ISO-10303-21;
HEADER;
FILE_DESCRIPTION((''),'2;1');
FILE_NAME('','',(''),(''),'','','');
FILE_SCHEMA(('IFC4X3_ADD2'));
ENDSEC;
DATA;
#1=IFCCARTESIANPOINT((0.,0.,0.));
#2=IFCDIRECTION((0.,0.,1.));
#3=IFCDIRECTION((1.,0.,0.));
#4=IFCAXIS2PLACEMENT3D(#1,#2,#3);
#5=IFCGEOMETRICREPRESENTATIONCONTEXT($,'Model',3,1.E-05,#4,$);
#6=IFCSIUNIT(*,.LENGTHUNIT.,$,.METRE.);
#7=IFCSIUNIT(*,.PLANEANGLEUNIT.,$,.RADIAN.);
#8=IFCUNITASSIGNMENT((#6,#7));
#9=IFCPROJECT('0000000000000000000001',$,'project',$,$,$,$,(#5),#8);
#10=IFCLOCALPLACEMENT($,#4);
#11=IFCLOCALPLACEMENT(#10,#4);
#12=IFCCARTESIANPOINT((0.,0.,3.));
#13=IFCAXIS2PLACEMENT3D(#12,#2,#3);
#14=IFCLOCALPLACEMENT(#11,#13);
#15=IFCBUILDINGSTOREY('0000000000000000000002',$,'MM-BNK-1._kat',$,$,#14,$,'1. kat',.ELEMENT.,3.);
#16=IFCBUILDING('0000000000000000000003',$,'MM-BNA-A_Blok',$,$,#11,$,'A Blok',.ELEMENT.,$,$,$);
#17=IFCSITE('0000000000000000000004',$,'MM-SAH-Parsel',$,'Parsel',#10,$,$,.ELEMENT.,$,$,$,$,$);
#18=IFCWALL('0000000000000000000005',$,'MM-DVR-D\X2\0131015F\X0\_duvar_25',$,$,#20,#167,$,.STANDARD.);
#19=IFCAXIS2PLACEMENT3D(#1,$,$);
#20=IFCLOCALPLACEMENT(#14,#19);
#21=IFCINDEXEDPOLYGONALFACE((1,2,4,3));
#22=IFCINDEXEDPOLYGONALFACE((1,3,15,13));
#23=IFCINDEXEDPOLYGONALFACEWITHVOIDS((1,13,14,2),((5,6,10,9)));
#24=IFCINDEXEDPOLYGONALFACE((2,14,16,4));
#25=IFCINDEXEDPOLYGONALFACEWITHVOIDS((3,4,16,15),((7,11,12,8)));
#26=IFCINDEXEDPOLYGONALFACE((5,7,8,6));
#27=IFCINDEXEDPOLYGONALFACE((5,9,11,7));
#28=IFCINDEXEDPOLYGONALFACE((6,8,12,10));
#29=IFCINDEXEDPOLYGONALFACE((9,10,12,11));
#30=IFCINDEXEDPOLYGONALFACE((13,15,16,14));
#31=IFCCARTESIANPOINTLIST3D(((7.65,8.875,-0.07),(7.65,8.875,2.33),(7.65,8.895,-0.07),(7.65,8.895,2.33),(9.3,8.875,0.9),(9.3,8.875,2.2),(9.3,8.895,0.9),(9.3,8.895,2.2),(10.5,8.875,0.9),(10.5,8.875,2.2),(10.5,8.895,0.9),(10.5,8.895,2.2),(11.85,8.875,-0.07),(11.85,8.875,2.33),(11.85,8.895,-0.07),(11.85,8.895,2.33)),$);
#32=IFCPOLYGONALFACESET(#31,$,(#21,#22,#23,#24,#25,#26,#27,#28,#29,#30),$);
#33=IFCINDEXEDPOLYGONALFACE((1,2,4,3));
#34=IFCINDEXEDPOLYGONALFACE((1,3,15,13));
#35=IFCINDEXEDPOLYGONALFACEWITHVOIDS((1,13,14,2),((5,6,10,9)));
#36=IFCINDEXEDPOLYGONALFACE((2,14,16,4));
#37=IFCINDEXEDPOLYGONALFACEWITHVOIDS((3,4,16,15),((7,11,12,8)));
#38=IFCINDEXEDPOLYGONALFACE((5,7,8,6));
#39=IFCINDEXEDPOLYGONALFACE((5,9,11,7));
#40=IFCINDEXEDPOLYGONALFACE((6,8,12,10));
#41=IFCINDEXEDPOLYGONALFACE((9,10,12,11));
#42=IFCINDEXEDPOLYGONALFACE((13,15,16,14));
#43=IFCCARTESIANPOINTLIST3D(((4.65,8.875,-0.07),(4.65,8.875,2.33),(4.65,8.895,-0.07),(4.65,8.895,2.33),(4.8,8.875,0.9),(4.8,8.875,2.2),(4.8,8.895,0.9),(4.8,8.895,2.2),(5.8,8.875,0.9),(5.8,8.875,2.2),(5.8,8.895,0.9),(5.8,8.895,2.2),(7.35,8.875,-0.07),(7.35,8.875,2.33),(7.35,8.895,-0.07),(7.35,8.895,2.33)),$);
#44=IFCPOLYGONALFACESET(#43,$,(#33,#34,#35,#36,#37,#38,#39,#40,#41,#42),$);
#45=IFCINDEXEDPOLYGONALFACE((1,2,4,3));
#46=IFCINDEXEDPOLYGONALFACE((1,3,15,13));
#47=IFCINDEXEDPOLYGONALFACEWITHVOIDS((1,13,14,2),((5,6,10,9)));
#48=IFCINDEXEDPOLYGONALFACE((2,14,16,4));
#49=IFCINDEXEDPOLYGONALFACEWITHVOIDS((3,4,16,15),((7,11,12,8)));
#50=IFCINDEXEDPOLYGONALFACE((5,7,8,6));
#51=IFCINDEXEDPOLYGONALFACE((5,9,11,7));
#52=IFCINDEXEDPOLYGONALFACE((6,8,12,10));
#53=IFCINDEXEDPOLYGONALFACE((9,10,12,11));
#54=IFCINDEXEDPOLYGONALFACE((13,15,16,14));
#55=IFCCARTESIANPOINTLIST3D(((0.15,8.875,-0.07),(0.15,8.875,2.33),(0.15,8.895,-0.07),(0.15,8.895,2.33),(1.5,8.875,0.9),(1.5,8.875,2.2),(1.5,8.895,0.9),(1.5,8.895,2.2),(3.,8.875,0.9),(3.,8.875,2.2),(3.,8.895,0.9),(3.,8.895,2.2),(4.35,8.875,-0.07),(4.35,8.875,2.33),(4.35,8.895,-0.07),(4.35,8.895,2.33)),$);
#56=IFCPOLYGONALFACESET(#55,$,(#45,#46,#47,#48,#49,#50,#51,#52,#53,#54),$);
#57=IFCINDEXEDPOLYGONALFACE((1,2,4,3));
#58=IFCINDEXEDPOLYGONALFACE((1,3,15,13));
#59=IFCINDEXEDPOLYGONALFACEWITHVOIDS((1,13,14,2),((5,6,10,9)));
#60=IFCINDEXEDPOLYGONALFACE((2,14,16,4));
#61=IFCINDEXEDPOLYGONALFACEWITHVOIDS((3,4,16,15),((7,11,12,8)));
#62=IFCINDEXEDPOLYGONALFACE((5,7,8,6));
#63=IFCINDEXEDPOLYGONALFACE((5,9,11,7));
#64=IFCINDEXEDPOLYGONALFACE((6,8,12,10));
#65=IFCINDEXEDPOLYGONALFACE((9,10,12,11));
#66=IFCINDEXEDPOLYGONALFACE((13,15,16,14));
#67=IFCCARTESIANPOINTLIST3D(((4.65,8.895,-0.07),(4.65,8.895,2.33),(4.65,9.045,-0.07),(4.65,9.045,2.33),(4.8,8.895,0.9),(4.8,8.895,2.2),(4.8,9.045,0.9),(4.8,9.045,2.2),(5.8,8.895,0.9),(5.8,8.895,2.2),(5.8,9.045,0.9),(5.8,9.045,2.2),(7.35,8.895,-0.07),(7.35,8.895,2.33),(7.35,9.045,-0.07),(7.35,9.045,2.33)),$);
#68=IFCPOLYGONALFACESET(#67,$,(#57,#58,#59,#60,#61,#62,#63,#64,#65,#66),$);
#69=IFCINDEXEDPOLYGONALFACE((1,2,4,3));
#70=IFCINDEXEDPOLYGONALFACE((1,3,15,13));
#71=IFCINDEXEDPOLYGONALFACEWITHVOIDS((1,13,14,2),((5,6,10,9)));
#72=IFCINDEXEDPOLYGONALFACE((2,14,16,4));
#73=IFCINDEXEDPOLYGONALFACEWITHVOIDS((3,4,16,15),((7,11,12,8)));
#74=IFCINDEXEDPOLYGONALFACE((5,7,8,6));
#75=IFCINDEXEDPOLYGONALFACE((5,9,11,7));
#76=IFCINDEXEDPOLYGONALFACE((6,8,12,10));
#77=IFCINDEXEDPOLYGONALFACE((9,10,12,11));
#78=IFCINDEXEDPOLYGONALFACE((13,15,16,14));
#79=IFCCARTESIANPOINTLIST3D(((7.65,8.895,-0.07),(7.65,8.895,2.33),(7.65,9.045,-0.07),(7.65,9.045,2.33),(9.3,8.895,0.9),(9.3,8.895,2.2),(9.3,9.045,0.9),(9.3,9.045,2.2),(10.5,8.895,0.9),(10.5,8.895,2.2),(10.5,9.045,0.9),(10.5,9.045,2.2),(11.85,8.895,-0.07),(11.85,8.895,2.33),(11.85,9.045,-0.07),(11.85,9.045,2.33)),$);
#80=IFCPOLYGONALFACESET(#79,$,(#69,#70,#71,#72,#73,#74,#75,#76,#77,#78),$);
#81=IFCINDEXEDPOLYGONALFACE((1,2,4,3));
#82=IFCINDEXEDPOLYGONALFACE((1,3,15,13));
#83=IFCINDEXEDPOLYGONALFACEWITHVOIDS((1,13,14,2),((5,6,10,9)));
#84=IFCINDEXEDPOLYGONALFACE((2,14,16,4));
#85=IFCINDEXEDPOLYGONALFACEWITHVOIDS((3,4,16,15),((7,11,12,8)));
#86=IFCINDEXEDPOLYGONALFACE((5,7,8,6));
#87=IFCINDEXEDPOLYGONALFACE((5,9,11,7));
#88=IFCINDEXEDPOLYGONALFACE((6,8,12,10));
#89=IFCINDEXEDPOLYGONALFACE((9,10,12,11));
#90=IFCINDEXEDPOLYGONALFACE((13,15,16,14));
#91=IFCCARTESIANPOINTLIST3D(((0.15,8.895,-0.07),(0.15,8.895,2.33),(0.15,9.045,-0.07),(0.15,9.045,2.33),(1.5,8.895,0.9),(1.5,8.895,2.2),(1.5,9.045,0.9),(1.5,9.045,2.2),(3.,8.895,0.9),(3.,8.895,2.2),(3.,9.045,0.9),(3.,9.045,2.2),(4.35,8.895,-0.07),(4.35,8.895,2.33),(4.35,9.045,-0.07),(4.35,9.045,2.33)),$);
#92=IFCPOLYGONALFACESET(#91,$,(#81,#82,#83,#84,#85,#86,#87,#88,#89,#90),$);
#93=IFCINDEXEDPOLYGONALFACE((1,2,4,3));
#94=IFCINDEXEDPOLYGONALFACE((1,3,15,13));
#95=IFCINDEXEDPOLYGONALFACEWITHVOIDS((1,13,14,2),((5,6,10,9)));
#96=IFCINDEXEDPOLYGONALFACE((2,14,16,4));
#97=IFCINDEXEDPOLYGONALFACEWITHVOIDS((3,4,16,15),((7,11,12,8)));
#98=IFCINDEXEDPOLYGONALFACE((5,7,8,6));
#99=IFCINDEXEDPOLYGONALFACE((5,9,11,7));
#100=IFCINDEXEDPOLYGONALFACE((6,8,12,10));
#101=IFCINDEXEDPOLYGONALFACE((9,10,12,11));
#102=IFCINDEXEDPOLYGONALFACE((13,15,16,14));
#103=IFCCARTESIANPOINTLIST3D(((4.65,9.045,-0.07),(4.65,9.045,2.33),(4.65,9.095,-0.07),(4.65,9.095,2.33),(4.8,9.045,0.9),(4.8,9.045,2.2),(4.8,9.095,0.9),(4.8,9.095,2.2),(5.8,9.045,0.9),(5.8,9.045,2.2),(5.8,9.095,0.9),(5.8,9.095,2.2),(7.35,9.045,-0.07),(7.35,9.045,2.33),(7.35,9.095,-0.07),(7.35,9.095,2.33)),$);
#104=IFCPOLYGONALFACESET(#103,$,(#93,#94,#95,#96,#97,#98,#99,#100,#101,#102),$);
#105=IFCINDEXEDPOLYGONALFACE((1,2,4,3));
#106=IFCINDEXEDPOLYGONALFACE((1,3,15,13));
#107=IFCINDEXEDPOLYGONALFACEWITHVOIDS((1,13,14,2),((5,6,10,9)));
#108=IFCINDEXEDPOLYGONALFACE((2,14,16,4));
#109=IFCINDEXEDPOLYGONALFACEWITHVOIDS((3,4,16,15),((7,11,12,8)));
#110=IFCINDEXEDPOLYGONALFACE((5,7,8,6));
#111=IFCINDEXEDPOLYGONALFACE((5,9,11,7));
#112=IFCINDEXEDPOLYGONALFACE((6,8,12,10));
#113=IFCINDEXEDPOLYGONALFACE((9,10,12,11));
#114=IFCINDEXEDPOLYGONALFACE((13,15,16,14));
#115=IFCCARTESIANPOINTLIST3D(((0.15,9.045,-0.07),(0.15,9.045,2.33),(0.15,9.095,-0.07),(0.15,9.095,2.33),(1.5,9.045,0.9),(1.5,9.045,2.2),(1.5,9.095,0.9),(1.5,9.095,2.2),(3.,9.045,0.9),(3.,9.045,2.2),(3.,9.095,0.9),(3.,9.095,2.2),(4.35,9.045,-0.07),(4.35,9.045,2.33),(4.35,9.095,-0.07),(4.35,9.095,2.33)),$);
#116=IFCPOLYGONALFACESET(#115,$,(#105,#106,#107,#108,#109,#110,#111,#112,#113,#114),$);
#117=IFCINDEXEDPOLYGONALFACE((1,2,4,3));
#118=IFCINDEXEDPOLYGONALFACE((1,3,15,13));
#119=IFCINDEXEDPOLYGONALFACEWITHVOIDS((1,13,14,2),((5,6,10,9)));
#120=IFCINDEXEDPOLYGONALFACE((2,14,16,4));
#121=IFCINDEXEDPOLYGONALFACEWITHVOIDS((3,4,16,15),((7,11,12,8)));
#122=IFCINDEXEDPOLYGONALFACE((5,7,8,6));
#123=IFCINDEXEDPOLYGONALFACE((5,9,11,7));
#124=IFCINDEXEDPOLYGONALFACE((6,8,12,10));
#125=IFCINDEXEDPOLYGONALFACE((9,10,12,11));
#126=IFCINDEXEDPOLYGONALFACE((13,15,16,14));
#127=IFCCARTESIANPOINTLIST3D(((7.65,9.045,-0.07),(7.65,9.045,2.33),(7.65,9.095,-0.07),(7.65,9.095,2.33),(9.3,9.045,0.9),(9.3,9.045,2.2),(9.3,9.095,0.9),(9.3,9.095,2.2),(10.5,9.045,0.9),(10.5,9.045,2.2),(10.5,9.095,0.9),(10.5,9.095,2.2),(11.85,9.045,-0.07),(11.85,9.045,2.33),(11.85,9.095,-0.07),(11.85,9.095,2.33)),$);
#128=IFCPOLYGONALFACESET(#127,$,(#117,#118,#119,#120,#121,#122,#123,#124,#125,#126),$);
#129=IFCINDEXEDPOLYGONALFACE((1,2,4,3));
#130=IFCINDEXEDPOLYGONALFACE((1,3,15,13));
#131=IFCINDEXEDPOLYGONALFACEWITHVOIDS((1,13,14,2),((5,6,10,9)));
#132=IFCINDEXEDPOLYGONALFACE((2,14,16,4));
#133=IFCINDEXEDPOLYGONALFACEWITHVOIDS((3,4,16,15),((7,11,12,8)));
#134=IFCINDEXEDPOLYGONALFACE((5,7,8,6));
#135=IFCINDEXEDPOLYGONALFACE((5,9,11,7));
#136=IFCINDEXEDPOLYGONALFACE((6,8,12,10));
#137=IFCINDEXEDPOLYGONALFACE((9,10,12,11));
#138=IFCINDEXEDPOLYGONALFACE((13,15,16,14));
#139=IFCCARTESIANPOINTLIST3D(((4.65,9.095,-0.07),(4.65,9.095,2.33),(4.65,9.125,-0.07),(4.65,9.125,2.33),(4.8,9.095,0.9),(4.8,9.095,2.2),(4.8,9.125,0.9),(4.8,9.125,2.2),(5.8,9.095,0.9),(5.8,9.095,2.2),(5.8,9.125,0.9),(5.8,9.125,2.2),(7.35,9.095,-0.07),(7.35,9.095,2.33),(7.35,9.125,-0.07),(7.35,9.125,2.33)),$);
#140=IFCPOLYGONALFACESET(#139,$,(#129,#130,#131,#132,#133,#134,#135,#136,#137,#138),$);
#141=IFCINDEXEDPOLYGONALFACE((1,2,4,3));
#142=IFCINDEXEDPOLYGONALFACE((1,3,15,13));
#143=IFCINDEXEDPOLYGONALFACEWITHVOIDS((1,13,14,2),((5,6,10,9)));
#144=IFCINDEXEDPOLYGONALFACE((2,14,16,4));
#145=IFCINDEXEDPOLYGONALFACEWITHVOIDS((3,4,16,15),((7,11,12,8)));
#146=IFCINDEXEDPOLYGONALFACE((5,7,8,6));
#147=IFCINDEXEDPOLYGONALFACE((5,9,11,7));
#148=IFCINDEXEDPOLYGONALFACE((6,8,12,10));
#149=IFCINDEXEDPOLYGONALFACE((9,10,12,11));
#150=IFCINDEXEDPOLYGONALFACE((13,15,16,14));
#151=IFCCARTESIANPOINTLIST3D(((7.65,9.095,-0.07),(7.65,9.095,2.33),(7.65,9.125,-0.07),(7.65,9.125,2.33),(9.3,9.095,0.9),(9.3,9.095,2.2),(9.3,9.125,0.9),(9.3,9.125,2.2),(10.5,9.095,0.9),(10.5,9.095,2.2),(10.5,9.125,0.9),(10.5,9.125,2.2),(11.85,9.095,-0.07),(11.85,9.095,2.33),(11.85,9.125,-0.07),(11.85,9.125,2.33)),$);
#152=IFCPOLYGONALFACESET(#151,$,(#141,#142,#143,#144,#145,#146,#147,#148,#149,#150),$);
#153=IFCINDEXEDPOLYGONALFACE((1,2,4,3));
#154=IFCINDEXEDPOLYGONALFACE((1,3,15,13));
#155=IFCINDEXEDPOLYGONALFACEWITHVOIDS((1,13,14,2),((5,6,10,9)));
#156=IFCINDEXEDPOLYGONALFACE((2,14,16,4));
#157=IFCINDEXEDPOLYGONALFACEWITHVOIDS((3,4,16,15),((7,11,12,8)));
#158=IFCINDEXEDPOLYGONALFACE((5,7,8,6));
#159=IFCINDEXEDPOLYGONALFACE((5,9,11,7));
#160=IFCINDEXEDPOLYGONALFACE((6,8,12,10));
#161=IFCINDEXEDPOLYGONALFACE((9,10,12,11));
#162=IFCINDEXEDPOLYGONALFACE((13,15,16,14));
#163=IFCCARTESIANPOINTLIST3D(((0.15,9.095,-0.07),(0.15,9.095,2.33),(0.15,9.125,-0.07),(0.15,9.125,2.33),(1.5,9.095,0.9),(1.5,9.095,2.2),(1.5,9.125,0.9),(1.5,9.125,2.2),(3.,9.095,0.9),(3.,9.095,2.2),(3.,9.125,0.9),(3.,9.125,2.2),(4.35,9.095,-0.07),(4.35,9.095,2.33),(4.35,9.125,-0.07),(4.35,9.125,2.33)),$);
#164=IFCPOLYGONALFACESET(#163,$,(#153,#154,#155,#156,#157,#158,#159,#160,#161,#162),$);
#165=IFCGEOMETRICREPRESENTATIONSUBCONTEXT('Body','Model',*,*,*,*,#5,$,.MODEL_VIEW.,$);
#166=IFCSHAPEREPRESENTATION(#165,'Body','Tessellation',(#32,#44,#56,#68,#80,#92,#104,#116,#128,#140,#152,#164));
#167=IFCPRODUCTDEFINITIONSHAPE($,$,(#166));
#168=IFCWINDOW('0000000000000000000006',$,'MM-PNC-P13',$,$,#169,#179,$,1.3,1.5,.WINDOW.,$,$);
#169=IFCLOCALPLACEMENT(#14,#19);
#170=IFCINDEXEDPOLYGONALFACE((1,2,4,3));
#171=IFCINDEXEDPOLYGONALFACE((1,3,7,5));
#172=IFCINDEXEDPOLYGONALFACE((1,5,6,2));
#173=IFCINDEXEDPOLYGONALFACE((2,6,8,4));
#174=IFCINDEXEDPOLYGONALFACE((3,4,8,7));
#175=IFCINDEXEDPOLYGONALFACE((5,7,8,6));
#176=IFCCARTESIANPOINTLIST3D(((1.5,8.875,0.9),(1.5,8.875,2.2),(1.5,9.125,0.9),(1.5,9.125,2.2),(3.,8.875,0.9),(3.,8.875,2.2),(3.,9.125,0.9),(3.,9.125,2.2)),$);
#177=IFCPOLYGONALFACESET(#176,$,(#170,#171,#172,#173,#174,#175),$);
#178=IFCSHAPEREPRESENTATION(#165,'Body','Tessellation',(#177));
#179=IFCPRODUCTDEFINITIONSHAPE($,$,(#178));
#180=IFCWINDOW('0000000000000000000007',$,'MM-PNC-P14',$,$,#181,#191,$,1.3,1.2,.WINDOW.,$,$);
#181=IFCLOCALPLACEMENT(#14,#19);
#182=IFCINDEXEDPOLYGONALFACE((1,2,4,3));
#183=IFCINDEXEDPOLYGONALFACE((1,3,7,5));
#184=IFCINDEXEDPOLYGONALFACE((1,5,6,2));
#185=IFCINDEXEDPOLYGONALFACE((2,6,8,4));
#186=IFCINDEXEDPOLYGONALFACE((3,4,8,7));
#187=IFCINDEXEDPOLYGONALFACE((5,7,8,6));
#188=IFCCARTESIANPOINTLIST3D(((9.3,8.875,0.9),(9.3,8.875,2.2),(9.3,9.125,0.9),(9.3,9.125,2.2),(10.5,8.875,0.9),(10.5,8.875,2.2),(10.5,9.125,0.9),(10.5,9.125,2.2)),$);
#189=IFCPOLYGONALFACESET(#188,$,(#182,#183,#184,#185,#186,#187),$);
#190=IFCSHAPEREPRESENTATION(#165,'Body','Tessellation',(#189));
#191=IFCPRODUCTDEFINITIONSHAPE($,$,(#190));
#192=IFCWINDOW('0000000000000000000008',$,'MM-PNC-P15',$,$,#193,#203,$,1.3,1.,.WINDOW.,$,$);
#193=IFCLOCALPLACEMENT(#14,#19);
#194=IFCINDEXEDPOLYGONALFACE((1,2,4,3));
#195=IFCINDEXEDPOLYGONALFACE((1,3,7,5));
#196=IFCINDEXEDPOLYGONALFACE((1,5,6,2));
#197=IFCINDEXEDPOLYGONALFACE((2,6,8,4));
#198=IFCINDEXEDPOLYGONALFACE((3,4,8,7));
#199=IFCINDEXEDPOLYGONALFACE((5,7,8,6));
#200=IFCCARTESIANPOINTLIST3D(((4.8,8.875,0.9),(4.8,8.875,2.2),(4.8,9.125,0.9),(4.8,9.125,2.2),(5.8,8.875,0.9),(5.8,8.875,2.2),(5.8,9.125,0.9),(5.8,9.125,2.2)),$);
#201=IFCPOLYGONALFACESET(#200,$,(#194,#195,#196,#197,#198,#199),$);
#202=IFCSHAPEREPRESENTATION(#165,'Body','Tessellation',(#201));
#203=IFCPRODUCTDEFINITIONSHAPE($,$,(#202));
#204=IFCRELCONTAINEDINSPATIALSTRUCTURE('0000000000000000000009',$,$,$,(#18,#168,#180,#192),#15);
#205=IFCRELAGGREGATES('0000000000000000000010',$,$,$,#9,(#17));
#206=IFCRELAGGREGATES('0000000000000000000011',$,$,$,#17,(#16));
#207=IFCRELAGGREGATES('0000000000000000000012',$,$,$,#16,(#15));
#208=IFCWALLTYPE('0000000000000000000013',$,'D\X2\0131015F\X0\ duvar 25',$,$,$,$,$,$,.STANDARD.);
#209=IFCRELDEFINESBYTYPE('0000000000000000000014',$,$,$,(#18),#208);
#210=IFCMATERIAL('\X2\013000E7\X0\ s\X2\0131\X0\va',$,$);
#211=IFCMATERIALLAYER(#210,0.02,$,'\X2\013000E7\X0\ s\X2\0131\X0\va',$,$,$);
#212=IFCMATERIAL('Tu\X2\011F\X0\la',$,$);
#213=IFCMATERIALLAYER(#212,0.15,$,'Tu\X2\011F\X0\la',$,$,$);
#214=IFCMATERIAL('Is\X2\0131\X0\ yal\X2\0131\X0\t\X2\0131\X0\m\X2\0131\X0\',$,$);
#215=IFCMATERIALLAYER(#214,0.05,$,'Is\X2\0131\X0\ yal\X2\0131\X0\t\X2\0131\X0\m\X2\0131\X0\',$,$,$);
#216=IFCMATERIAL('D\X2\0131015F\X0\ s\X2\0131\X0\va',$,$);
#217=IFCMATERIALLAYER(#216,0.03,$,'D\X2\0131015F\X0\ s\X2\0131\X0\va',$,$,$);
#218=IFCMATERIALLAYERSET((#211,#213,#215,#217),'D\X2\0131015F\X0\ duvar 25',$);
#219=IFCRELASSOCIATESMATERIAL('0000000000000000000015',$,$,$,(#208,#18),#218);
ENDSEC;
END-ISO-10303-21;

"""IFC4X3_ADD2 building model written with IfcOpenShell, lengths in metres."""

from ifc_helpers import new_model, si_unit, frame, origin_with_axes, place, context, subcontext, project, spatial, polyline, outline, extrude, material, layer, layer_set, type_object, element, fill, save


model = new_model("IFC4X3_ADD2")

# Units and contexts
model_context = context("Model", 3, precision=1e-05, world=origin_with_axes())
body_context = subcontext(model_context, "Body", "Model", "MODEL_VIEW")
ifc_project = project(units=[si_unit("LENGTHUNIT", "METRE"), si_unit("PLANEANGLEUNIT", "RADIAN")], contexts=[model_context])

# Site, building, storey
site_placement = place(None, origin_with_axes())
site = spatial("IfcSite", under=ifc_project, at=site_placement, Name="MM-SAH-Parsel", ObjectType="Parsel", CompositionType="ELEMENT")
building_placement = place(site_placement, origin_with_axes())
building = spatial("IfcBuilding", under=site, at=building_placement, Name="MM-BNA-A_Blok", LongName="A Blok", CompositionType="ELEMENT")
storey_placement = place(building_placement, frame((0.0, 0.0, 3.0), z_axis=(0.0, 0.0, 1.0), x_axis=(1.0, 0.0, 0.0)))
storey = spatial("IfcBuildingStorey", under=building, at=storey_placement, Name="MM-BNK-1._kat", LongName="1. kat", CompositionType="ELEMENT", Elevation=3.0)

# Shared definitions
ifc_material_1 = material(Name="İç sıva")
ifc_layer_1 = layer(ifc_material_1, 0.02, Name="İç sıva")
ifc_material_2 = material(Name="Tuğla")
ifc_layer_2 = layer(ifc_material_2, 0.15, Name="Tuğla")
ifc_material_3 = material(Name="Isı yalıtımı")
ifc_layer_3 = layer(ifc_material_3, 0.05, Name="Isı yalıtımı")
ifc_material_4 = material(Name="Dış sıva")
ifc_layer_4 = layer(ifc_material_4, 0.03, Name="Dış sıva")
ifc_layer_set_1 = layer_set([ifc_layer_1, ifc_layer_2, ifc_layer_3, ifc_layer_4], Name="Dış duvar 25")
wall_type_1 = type_object("IfcWallType", Name="Dış duvar 25", PredefinedType="STANDARD", material=ifc_layer_set_1)

# Wall, openings, windows
wall_1_placement = place(storey_placement, origin_with_axes())
wall_1 = element("IfcWall", 1, at=wall_1_placement, inside=storey, type_object=wall_type_1, material=ifc_layer_set_1, Name="MM-DVR-Dış_duvar_25", PredefinedType="STANDARD", context=body_context, shape_type="SweptSolid", body=[
    extrude(outline(polyline([(11.85, 8.895), (7.65, 8.895), (7.65, 8.875), (11.85, 8.875), (11.85, 8.895)])), frame((0.0, 0.0, -0.07)), (0.0, 0.0, 1.0), 2.4),
    extrude(outline(polyline([(7.35, 8.895), (4.65, 8.895), (4.65, 8.875), (7.35, 8.875), (7.35, 8.895)])), frame((0.0, 0.0, -0.07)), (0.0, 0.0, 1.0), 2.4),
    extrude(outline(polyline([(4.35, 8.895), (0.15, 8.895), (0.15, 8.875), (4.35, 8.875), (4.35, 8.895)])), frame((0.0, 0.0, -0.07)), (0.0, 0.0, 1.0), 2.4),
    extrude(outline(polyline([(7.35, 9.045), (4.65, 9.045), (4.65, 8.895), (7.35, 8.895), (7.35, 9.045)])), frame((0.0, 0.0, -0.07)), (0.0, 0.0, 1.0), 2.4),
    extrude(outline(polyline([(11.85, 9.045), (7.65, 9.045), (7.65, 8.895), (11.85, 8.895), (11.85, 9.045)])), frame((0.0, 0.0, -0.07)), (0.0, 0.0, 1.0), 2.4),
    extrude(outline(polyline([(4.35, 9.045), (0.15, 9.045), (0.15, 8.895), (4.35, 8.895), (4.35, 9.045)])), frame((0.0, 0.0, -0.07)), (0.0, 0.0, 1.0), 2.4),
    extrude(outline(polyline([(7.35, 9.095), (4.65, 9.095), (4.65, 9.045), (7.35, 9.045), (7.35, 9.095)])), frame((0.0, 0.0, -0.07)), (0.0, 0.0, 1.0), 2.4),
    extrude(outline(polyline([(4.35, 9.095), (0.15, 9.095), (0.15, 9.045), (4.35, 9.045), (4.35, 9.095)])), frame((0.0, 0.0, -0.07)), (0.0, 0.0, 1.0), 2.4),
    extrude(outline(polyline([(11.85, 9.095), (7.65, 9.095), (7.65, 9.045), (11.85, 9.045), (11.85, 9.095)])), frame((0.0, 0.0, -0.07)), (0.0, 0.0, 1.0), 2.4),
    extrude(outline(polyline([(7.35, 9.125), (4.65, 9.125), (4.65, 9.095), (7.35, 9.095), (7.35, 9.125)])), frame((0.0, 0.0, -0.07)), (0.0, 0.0, 1.0), 2.4),
    extrude(outline(polyline([(11.85, 9.125), (7.65, 9.125), (7.65, 9.095), (11.85, 9.095), (11.85, 9.125)])), frame((0.0, 0.0, -0.07)), (0.0, 0.0, 1.0), 2.4),
    extrude(outline(polyline([(4.35, 9.125), (0.15, 9.125), (0.15, 9.095), (4.35, 9.095), (4.35, 9.125)])), frame((0.0, 0.0, -0.07)), (0.0, 0.0, 1.0), 2.4),
])
opening_1_placement = place(storey_placement, origin_with_axes())
opening_1 = element("IfcOpeningElement", 2, at=opening_1_placement, cuts=wall_1, PredefinedType="OPENING", context=body_context, shape_type="SweptSolid", body=[
    extrude(outline(polyline([(3.0, 8.875), (1.5, 8.875), (1.5, 9.125), (3.0, 9.125), (3.0, 8.875)])), frame((0.0, 0.0, 0.9)), (0.0, 0.0, 1.0), 1.3),
])
opening_2_placement = place(storey_placement, origin_with_axes())
opening_2 = element("IfcOpeningElement", 3, at=opening_2_placement, cuts=wall_1, PredefinedType="OPENING", context=body_context, shape_type="SweptSolid", body=[
    extrude(outline(polyline([(10.5, 8.875), (9.3, 8.875), (9.3, 9.125), (10.5, 9.125), (10.5, 8.875)])), frame((0.0, 0.0, 0.9)), (0.0, 0.0, 1.0), 1.3),
])
opening_3_placement = place(storey_placement, origin_with_axes())
opening_3 = element("IfcOpeningElement", 4, at=opening_3_placement, cuts=wall_1, PredefinedType="OPENING", context=body_context, shape_type="SweptSolid", body=[
    extrude(outline(polyline([(5.8, 8.875), (4.8, 8.875), (4.8, 9.125), (5.8, 9.125), (5.8, 8.875)])), frame((0.0, 0.0, 0.9)), (0.0, 0.0, 1.0), 1.3),
])
window_1_placement = place(storey_placement, origin_with_axes())
window_1 = element("IfcWindow", 5, at=window_1_placement, inside=storey, Name="MM-PNC-P13", OverallHeight=1.3, OverallWidth=1.5, PredefinedType="WINDOW", context=body_context, shape_type="SweptSolid", body=[
    extrude(outline(polyline([(3.0, 8.875), (1.5, 8.875), (1.5, 9.125), (3.0, 9.125), (3.0, 8.875)])), frame((0.0, 0.0, 0.9)), (0.0, 0.0, 1.0), 1.3),
])
fill(opening_1, window_1)
window_2_placement = place(storey_placement, origin_with_axes())
window_2 = element("IfcWindow", 6, at=window_2_placement, inside=storey, Name="MM-PNC-P14", OverallHeight=1.3, OverallWidth=1.2, PredefinedType="WINDOW", context=body_context, shape_type="SweptSolid", body=[
    extrude(outline(polyline([(10.5, 8.875), (9.3, 8.875), (9.3, 9.125), (10.5, 9.125), (10.5, 8.875)])), frame((0.0, 0.0, 0.9)), (0.0, 0.0, 1.0), 1.3),
])
fill(opening_2, window_2)
window_3_placement = place(storey_placement, origin_with_axes())
window_3 = element("IfcWindow", 7, at=window_3_placement, inside=storey, Name="MM-PNC-P15", OverallHeight=1.3, OverallWidth=1.0, PredefinedType="WINDOW", context=body_context, shape_type="SweptSolid", body=[
    extrude(outline(polyline([(5.8, 8.875), (4.8, 8.875), (4.8, 9.125), (5.8, 9.125), (5.8, 8.875)])), frame((0.0, 0.0, 0.9)), (0.0, 0.0, 1.0), 1.3),
])
fill(opening_3, window_3)

save(model, "model.ifc")
